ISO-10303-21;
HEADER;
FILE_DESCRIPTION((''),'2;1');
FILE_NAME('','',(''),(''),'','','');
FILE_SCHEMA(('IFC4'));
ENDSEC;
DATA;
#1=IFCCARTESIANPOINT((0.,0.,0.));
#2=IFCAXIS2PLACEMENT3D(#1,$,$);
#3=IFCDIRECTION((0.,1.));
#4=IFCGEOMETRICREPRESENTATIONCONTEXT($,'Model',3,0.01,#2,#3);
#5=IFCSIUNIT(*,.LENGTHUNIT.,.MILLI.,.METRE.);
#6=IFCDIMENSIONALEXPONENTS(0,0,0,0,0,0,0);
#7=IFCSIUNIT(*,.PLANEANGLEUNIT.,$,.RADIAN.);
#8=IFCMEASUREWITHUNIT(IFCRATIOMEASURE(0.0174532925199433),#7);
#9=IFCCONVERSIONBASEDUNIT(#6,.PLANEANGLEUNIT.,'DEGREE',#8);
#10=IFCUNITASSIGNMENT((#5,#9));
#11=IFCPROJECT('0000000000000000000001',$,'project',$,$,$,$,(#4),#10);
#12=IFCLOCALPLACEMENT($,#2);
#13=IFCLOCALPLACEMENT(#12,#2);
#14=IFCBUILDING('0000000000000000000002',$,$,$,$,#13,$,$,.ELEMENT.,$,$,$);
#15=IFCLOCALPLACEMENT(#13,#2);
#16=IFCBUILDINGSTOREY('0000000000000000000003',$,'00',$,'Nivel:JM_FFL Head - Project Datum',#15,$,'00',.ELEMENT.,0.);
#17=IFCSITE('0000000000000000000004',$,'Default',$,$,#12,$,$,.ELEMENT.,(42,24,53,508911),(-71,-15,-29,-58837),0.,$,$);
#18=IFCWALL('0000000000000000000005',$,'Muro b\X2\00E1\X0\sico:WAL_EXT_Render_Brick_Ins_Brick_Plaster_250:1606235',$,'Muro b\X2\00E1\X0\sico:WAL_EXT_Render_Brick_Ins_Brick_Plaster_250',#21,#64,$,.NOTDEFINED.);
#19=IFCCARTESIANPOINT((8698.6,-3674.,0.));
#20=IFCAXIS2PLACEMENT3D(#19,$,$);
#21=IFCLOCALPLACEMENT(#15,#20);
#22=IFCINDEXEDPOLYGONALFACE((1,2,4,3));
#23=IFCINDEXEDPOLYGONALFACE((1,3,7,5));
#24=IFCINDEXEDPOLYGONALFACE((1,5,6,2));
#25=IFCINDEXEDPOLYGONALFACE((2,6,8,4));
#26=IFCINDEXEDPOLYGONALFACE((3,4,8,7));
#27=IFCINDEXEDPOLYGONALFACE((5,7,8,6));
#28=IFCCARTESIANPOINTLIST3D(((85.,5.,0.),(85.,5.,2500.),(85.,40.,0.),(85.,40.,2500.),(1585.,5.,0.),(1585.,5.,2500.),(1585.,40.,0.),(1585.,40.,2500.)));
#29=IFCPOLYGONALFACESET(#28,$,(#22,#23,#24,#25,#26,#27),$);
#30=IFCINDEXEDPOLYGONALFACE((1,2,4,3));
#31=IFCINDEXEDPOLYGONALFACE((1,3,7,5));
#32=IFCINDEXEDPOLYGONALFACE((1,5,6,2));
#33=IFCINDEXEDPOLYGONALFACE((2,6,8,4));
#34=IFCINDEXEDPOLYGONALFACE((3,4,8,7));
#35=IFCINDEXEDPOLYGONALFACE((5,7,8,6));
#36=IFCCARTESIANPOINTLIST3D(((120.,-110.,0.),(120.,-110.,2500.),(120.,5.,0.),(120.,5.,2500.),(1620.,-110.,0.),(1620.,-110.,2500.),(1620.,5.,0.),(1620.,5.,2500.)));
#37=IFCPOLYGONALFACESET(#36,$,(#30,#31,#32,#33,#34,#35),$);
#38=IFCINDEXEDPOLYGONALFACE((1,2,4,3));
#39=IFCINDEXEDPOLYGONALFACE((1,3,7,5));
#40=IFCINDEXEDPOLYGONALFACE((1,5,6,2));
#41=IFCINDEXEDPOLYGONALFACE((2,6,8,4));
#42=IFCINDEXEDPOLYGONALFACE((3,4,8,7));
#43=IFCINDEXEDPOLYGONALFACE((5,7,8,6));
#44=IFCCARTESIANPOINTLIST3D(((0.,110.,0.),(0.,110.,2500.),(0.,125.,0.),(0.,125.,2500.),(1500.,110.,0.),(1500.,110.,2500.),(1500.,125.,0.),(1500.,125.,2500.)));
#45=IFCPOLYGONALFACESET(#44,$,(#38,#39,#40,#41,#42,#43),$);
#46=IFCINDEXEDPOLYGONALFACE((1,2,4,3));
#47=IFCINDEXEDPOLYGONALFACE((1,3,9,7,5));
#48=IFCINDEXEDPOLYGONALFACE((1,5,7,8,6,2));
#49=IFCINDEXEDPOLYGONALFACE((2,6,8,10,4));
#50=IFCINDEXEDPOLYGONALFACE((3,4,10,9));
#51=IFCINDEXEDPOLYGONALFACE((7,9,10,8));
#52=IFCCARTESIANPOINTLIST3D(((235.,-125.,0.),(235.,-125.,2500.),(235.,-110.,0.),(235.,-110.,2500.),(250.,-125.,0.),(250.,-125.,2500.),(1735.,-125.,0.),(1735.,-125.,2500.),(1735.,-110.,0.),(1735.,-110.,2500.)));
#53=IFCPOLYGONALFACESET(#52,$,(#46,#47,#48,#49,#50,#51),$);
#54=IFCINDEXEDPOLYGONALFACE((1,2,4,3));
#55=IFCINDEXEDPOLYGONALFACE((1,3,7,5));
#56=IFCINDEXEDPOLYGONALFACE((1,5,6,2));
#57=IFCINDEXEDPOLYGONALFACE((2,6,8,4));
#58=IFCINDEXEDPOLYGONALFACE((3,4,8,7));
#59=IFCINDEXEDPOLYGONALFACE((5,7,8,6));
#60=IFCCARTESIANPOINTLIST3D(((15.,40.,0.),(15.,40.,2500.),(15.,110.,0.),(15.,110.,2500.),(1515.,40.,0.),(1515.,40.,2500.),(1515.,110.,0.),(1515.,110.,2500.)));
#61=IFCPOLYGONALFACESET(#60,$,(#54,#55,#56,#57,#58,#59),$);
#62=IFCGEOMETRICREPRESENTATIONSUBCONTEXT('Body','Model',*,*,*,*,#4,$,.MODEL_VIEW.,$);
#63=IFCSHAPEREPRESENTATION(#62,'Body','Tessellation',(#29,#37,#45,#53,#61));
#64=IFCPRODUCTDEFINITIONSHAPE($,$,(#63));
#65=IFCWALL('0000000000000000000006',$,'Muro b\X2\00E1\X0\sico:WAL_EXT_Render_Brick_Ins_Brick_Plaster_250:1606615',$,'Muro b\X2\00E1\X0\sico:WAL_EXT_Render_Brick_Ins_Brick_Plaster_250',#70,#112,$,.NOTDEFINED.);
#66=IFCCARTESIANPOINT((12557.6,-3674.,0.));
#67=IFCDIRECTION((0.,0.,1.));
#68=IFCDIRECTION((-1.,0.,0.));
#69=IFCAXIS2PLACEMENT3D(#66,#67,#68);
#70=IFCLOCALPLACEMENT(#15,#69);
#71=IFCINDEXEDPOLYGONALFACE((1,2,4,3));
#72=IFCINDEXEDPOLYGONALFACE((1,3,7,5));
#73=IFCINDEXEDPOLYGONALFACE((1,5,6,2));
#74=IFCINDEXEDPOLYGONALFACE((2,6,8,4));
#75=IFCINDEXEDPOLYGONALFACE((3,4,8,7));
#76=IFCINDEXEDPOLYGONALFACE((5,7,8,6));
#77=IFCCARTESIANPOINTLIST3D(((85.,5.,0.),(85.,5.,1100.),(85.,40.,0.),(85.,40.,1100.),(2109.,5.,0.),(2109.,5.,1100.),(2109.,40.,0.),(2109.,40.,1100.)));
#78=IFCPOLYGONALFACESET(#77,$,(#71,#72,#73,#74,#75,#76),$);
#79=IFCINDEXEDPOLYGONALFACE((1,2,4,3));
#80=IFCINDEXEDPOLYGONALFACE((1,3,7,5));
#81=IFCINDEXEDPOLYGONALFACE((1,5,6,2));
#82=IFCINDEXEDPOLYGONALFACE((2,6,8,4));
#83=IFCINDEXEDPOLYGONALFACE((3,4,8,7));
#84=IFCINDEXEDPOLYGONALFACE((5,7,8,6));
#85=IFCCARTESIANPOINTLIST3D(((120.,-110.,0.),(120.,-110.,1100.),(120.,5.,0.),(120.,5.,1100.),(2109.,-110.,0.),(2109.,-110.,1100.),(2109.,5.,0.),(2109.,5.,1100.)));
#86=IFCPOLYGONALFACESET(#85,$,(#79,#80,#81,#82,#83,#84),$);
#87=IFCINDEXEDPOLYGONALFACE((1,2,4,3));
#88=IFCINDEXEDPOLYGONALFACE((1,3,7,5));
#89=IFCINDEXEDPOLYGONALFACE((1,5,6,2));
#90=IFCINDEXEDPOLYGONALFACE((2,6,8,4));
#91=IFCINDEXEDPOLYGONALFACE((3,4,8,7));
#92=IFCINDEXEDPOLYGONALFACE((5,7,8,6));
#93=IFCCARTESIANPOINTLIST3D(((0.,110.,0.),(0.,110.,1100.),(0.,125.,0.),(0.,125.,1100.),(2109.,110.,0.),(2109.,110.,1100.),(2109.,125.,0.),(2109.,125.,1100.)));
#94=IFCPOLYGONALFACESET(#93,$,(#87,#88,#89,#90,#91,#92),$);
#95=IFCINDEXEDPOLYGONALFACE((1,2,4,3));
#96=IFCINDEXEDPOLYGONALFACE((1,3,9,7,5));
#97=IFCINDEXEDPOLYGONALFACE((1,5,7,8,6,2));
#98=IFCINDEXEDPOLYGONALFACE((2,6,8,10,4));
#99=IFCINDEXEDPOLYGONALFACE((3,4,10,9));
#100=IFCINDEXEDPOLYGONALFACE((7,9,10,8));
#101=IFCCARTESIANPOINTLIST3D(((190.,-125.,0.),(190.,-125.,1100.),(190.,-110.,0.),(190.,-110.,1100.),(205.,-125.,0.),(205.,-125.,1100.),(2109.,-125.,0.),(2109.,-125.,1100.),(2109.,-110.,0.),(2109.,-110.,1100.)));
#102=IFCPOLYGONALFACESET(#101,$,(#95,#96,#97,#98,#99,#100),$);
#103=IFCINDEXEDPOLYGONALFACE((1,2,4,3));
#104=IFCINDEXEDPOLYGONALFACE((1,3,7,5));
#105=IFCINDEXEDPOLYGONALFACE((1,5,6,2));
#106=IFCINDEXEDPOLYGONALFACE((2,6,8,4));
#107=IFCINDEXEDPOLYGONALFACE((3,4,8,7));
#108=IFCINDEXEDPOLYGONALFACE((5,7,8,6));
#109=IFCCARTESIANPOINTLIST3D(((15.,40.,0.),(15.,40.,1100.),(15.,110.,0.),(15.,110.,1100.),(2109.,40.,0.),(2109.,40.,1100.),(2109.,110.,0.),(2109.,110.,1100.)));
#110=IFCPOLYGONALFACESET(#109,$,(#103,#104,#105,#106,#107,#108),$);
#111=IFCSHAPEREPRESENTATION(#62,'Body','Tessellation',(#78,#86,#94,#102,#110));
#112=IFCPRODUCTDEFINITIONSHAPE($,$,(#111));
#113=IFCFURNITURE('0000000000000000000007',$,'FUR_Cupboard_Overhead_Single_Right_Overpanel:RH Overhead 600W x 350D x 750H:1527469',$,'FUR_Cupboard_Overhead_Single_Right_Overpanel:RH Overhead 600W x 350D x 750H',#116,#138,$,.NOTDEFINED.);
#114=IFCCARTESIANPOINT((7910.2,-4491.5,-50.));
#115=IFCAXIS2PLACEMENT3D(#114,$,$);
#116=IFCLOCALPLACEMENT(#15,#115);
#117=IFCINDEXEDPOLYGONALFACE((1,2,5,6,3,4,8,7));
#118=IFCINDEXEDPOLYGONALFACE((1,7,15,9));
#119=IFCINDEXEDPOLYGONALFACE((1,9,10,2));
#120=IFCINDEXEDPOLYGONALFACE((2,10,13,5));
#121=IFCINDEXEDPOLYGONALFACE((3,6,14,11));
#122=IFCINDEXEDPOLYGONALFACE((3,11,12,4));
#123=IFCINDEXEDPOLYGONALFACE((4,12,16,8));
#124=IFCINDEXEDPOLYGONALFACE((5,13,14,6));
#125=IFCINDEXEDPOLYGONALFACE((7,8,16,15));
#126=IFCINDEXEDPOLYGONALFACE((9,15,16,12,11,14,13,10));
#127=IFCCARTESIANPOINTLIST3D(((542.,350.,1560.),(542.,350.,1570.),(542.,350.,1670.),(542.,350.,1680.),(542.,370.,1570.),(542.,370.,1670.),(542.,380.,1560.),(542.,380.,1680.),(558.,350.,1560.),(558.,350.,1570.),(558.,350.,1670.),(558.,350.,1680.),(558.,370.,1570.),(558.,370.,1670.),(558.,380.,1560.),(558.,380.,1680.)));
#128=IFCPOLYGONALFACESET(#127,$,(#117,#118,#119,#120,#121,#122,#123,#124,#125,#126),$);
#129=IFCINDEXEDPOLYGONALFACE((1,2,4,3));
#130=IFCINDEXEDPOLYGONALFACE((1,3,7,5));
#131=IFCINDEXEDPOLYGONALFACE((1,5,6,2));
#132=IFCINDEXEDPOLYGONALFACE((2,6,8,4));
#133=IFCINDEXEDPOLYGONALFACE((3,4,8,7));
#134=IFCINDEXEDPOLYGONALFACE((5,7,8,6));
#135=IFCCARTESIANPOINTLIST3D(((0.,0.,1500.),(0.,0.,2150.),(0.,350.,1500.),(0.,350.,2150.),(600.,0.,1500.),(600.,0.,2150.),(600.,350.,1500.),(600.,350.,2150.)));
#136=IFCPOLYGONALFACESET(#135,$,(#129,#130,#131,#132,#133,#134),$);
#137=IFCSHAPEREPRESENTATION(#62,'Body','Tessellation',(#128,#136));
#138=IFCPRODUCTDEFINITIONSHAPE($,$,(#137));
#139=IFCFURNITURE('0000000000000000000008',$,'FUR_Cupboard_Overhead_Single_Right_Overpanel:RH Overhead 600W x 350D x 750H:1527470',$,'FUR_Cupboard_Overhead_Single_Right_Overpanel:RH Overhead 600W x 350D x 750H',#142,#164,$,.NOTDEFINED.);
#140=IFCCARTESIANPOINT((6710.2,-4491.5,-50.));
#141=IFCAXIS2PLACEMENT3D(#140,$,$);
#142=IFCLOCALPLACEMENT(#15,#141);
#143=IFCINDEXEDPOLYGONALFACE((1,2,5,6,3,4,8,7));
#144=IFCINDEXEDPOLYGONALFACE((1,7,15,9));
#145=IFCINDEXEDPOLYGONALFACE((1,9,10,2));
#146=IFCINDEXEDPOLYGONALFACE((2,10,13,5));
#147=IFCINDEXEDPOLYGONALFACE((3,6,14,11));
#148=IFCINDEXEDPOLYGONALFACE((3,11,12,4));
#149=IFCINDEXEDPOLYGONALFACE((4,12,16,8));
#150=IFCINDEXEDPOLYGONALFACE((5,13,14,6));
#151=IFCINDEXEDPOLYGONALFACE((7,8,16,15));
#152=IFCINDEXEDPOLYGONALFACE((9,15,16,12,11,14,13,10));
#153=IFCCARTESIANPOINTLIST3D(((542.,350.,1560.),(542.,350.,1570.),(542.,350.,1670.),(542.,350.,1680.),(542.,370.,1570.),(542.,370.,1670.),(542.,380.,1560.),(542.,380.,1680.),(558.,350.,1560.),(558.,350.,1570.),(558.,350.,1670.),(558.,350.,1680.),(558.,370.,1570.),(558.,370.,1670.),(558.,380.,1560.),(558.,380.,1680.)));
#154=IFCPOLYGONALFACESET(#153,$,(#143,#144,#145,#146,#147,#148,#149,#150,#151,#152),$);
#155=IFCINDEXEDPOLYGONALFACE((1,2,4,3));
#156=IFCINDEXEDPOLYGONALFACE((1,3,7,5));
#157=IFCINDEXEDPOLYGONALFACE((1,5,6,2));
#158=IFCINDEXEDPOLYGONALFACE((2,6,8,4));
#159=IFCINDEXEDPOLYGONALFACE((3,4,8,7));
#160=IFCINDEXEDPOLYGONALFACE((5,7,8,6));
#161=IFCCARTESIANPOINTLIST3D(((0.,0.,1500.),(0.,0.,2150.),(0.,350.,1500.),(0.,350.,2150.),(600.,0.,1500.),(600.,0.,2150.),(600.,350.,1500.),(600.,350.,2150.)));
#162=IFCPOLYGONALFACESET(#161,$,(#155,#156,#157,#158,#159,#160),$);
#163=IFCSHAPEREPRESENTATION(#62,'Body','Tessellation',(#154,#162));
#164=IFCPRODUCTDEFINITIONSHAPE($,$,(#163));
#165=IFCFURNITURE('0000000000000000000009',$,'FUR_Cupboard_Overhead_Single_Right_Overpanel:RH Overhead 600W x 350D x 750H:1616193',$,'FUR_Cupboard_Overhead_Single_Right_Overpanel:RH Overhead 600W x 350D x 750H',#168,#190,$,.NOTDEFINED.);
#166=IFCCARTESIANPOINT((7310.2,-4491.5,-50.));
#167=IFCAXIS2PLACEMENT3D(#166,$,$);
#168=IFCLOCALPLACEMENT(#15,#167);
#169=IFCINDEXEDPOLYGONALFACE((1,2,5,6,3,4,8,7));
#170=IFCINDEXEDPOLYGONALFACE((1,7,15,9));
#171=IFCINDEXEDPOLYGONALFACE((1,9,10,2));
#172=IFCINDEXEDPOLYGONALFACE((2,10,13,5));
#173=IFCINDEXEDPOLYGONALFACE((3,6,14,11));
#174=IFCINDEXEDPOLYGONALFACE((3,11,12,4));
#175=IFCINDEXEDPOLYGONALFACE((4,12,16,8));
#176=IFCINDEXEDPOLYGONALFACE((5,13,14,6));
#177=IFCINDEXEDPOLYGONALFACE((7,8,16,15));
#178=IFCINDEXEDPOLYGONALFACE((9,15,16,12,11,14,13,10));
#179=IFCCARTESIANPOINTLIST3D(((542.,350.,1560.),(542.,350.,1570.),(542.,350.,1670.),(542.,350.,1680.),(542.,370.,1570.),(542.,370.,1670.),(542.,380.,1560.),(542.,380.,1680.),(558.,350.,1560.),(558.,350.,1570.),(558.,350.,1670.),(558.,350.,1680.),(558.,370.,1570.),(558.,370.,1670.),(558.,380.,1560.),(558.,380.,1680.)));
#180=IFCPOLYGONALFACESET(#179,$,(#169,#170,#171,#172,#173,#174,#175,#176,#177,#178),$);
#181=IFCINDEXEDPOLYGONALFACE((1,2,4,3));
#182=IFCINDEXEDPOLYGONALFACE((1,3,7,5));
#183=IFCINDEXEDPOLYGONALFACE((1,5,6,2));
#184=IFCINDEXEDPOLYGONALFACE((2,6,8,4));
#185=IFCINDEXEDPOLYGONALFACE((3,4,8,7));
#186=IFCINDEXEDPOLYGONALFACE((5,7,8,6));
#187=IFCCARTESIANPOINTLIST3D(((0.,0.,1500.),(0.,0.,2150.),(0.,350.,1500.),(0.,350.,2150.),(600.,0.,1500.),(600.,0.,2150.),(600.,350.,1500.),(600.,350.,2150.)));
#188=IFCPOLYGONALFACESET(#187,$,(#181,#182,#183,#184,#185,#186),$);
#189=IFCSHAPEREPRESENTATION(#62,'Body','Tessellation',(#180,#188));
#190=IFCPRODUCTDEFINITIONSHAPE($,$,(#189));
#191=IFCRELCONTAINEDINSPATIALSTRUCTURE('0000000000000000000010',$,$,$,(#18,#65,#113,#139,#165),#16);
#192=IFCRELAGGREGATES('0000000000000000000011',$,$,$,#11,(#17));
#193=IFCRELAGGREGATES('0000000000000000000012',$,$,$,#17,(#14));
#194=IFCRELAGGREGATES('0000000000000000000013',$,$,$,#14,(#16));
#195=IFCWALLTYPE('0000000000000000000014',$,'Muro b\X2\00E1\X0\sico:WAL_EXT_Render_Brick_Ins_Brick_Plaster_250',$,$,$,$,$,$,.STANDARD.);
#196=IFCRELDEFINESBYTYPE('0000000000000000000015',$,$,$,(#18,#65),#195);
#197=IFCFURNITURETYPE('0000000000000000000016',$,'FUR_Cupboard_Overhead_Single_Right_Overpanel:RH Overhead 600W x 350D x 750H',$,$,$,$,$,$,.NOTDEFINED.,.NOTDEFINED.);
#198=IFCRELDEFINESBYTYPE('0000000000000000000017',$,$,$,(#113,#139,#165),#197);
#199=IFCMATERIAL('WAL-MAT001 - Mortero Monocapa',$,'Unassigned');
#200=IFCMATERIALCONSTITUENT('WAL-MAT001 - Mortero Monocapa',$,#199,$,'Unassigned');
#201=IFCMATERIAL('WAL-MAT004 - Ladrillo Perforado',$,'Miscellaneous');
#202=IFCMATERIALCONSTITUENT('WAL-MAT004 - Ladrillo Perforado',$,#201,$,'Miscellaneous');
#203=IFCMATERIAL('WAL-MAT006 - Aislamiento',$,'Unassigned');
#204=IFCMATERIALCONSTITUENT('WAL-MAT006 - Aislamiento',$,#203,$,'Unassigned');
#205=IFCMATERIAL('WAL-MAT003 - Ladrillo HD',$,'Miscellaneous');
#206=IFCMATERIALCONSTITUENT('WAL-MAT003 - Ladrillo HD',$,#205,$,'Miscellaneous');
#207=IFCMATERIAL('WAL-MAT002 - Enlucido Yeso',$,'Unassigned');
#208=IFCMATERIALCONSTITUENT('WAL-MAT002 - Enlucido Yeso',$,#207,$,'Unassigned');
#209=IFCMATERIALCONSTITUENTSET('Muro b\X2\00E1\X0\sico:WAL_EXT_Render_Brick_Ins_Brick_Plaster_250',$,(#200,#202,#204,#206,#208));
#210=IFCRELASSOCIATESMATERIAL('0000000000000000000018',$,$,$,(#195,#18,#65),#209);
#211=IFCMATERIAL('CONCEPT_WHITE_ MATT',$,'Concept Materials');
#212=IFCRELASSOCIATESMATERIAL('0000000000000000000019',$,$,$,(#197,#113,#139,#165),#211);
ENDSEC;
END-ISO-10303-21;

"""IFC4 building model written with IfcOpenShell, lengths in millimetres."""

from ifc_helpers import new_model, entity, si_unit, converted_unit, direction, frame, origin, place, context, subcontext, project, spatial, indexed_curve, outline, extrude, source, transform, mapped, material, constituent, constituent_set, type_object, type_shapes, element, save


model = new_model("IFC4")

# Units and contexts
model_context = context("Model", 3, precision=0.01, world=origin(), true_north=direction((0.0, 1.0)))
body_context = subcontext(model_context, "Body", "Model", "MODEL_VIEW")
ifc_project = project(units=[si_unit("LENGTHUNIT", "METRE", prefix="MILLI"), converted_unit("PLANEANGLEUNIT", "DEGREE", entity("IfcRatioMeasure", 0.0174532925199433), si_unit("PLANEANGLEUNIT", "RADIAN"), dimensions=[0, 0, 0, 0, 0, 0, 0])], contexts=[model_context])

# Site, building, storey
site_placement = place(None, origin())
site = spatial("IfcSite", under=ifc_project, at=site_placement, Name="Default", CompositionType="ELEMENT", RefLatitude=(42, 24, 53, 508911), RefLongitude=(-71, -15, -29, -58837), RefElevation=0.0)
building_placement = place(site_placement, origin())
building = spatial("IfcBuilding", under=site, at=building_placement, CompositionType="ELEMENT")
storey_placement = place(building_placement, origin())
storey = spatial("IfcBuildingStorey", under=building, at=storey_placement, Name="00", ObjectType="Nivel:JM_FFL Head - Project Datum", LongName="00", CompositionType="ELEMENT", Elevation=0.0)

# Walls
ifc_material_1 = material(Name="WAL-MAT001 - Mortero Monocapa", Category="Unassigned")
ifc_material_2 = material(Name="WAL-MAT004 - Ladrillo Perforado", Category="Miscellaneous")
ifc_material_3 = material(Name="WAL-MAT006 - Aislamiento", Category="Unassigned")
ifc_material_4 = material(Name="WAL-MAT003 - Ladrillo HD", Category="Miscellaneous")
ifc_material_5 = material(Name="WAL-MAT002 - Enlucido Yeso", Category="Unassigned")
ifc_constituent_1 = constituent(ifc_material_1, Name="WAL-MAT001 - Mortero Monocapa", Category="Unassigned")
ifc_constituent_2 = constituent(ifc_material_2, Name="WAL-MAT004 - Ladrillo Perforado", Category="Miscellaneous")
ifc_constituent_3 = constituent(ifc_material_3, Name="WAL-MAT006 - Aislamiento", Category="Unassigned")
ifc_constituent_4 = constituent(ifc_material_4, Name="WAL-MAT003 - Ladrillo HD", Category="Miscellaneous")
ifc_constituent_5 = constituent(ifc_material_5, Name="WAL-MAT002 - Enlucido Yeso", Category="Unassigned")
ifc_constituent_set_1 = constituent_set(constituents=[ifc_constituent_1, ifc_constituent_2, ifc_constituent_3, ifc_constituent_4, ifc_constituent_5], Name="Muro básico:WAL_EXT_Render_Brick_Ins_Brick_Plaster_250")
wall_type_1 = type_object("IfcWallType", Name="Muro básico:WAL_EXT_Render_Brick_Ins_Brick_Plaster_250", PredefinedType="STANDARD", material=ifc_constituent_set_1)
wall_1_placement = place(storey_placement, frame((8698.6, -3674.0, 0.0)))
element("IfcWall", 1, at=wall_1_placement, inside=storey, type_object=wall_type_1, material=ifc_constituent_set_1, Name="Muro básico:WAL_EXT_Render_Brick_Ins_Brick_Plaster_250:1606235", ObjectType="Muro básico:WAL_EXT_Render_Brick_Ins_Brick_Plaster_250", PredefinedType="NOTDEFINED", context=body_context, shape_type="SweptSolid", body=[
    extrude(outline(indexed_curve([(-17.5, -750.0), (17.5, -750.0), (17.5, 750.0), (-17.5, 750.0), (-17.5, -750.0)], self_intersect=False)), frame((835.0, 22.5, 0.0), z_axis=(0.0, 0.0, 1.0), x_axis=(0.0, 1.0, 0.0)), (0.0, 0.0, 1.0), 2500.0),
    extrude(outline(indexed_curve([(-57.5, -750.0), (57.5, -750.0), (57.5, 750.0), (-57.5, 750.0), (-57.5, -750.0)], self_intersect=False)), frame((870.0, -52.5, 0.0), z_axis=(0.0, 0.0, 1.0), x_axis=(0.0, -1.0, 0.0)), (0.0, 0.0, 1.0), 2500.0),
    extrude(outline(indexed_curve([(-7.5, -750.0), (7.5, -750.0), (7.5, 750.0), (-7.5, 750.0), (-7.5, -750.0)], self_intersect=False)), frame((750.0, 117.5, 0.0), z_axis=(0.0, 0.0, 1.0), x_axis=(0.0, 1.0, 0.0)), (0.0, 0.0, 1.0), 2500.0),
    extrude(outline(indexed_curve([(-9.0, -603.0), (6.0, -603.0), (6.0, -588.0), (6.0, 897.0), (-9.0, 897.0), (-9.0, -603.0)], self_intersect=False)), frame((838.0, -119.0, 0.0), z_axis=(0.0, 0.0, 1.0), x_axis=(0.0, -1.0, 0.0)), (0.0, 0.0, 1.0), 2500.0),
    extrude(outline(indexed_curve([(-35.0, -750.0), (35.0, -750.0), (35.0, 750.0), (-35.0, 750.0), (-35.0, -750.0)], self_intersect=False)), frame((765.0, 75.0, 0.0), z_axis=(0.0, 0.0, 1.0), x_axis=(0.0, 1.0, 0.0)), (0.0, 0.0, 1.0), 2500.0),
])
wall_2_placement = place(storey_placement, frame((12557.6, -3674.0, 0.0), z_axis=(0.0, 0.0, 1.0), x_axis=(-1.0, 0.0, 0.0)))
element("IfcWall", 2, at=wall_2_placement, inside=storey, type_object=wall_type_1, material=ifc_constituent_set_1, Name="Muro básico:WAL_EXT_Render_Brick_Ins_Brick_Plaster_250:1606615", ObjectType="Muro básico:WAL_EXT_Render_Brick_Ins_Brick_Plaster_250", PredefinedType="NOTDEFINED", context=body_context, shape_type="SweptSolid", body=[
    extrude(outline(indexed_curve([(-1012.0, -17.5), (1012.0, -17.5), (1012.0, 17.5), (-1012.0, 17.5), (-1012.0, -17.5)], self_intersect=False)), frame((1097.0, 22.5, 0.0)), (0.0, 0.0, 1.0), 1100.0),
    extrude(outline(indexed_curve([(-994.5, -57.5), (994.5, -57.5), (994.5, 57.5), (-994.5, 57.5), (-994.5, -57.5)], self_intersect=False)), frame((1114.5, -52.5, 0.0)), (0.0, 0.0, 1.0), 1100.0),
    extrude(outline(indexed_curve([(-7.5, -1054.5), (7.5, -1054.5), (7.5, 1054.5), (-7.5, 1054.5), (-7.5, -1054.5)], self_intersect=False)), frame((1054.5, 117.5, 0.0), z_axis=(0.0, 0.0, 1.0), x_axis=(0.0, -1.0, 0.0)), (0.0, 0.0, 1.0), 1100.0),
    extrude(outline(indexed_curve([(-755.6, -6.0), (1148.4, -6.0), (1148.4, 9.0), (-770.6, 9.0), (-770.6, -6.0), (-755.6, -6.0)], self_intersect=False)), frame((960.6, -119.0, 0.0)), (0.0, 0.0, 1.0), 1100.0),
    extrude(outline(indexed_curve([(-1047.0, -35.0), (1047.0, -35.0), (1047.0, 35.0), (-1047.0, 35.0), (-1047.0, -35.0)], self_intersect=False)), frame((1062.0, 75.0, 0.0)), (0.0, 0.0, 1.0), 1100.0),
])

# Furniture
ifc_material_6 = material(Name="CONCEPT_WHITE_ MATT", Category="Concept Materials")
furniture_type_1 = type_object("IfcFurnitureType", Name="FUR_Cupboard_Overhead_Single_Right_Overpanel:RH Overhead 600W x 350D x 750H", AssemblyPlace="NOTDEFINED", PredefinedType="NOTDEFINED", material=ifc_material_6)
shared_shape_1 = source(origin(), body_context, "Body", "SweptSolid", [
    extrude(outline(indexed_curve([(-17.5, -60.0), (12.5, -60.0), (12.5, -50.0), (-7.5, -50.0), (-7.5, 50.0), (12.5, 50.0), (12.5, 60.0), (-17.5, 60.0), (-17.5, -60.0)], self_intersect=False)), frame((542.0, 362.5, 1620.0), z_axis=(1.0, 0.0, 0.0), x_axis=(0.0, -1.0, 0.0)), (0.0, 0.0, 1.0), 16.0),
    extrude(outline(indexed_curve([(-300.0, -175.0), (300.0, -175.0), (300.0, 175.0), (-300.0, 175.0), (-300.0, -175.0)], self_intersect=False)), frame((300.0, 175.0, 1500.0), z_axis=(0.0, 0.0, 1.0), x_axis=(-1.0, 0.0, 0.0)), (0.0, 0.0, 1.0), 650.0),
])
type_shapes(furniture_type_1, [shared_shape_1])
for number, where, name in (
    (3, (7910.2, -4491.5, -50.0), "FUR_Cupboard_Overhead_Single_Right_Overpanel:RH Overhead 600W x 350D x 750H:1527469"),
    (4, (6710.2, -4491.5, -50.0), "FUR_Cupboard_Overhead_Single_Right_Overpanel:RH Overhead 600W x 350D x 750H:1527470"),
    (5, (7310.2, -4491.5, -50.0), "FUR_Cupboard_Overhead_Single_Right_Overpanel:RH Overhead 600W x 350D x 750H:1616193"),
):
    element("IfcFurniture", number, at=place(storey_placement, frame(where)), inside=storey, type_object=furniture_type_1, material=ifc_material_6, Name=name, ObjectType="FUR_Cupboard_Overhead_Single_Right_Overpanel:RH Overhead 600W x 350D x 750H", PredefinedType="NOTDEFINED", context=body_context, shape_type="MappedRepresentation", body=[
        mapped(shared_shape_1, transform((0.0, 0.0, 0.0), scale=1.0)),
    ])

save(model, "model.ifc")
